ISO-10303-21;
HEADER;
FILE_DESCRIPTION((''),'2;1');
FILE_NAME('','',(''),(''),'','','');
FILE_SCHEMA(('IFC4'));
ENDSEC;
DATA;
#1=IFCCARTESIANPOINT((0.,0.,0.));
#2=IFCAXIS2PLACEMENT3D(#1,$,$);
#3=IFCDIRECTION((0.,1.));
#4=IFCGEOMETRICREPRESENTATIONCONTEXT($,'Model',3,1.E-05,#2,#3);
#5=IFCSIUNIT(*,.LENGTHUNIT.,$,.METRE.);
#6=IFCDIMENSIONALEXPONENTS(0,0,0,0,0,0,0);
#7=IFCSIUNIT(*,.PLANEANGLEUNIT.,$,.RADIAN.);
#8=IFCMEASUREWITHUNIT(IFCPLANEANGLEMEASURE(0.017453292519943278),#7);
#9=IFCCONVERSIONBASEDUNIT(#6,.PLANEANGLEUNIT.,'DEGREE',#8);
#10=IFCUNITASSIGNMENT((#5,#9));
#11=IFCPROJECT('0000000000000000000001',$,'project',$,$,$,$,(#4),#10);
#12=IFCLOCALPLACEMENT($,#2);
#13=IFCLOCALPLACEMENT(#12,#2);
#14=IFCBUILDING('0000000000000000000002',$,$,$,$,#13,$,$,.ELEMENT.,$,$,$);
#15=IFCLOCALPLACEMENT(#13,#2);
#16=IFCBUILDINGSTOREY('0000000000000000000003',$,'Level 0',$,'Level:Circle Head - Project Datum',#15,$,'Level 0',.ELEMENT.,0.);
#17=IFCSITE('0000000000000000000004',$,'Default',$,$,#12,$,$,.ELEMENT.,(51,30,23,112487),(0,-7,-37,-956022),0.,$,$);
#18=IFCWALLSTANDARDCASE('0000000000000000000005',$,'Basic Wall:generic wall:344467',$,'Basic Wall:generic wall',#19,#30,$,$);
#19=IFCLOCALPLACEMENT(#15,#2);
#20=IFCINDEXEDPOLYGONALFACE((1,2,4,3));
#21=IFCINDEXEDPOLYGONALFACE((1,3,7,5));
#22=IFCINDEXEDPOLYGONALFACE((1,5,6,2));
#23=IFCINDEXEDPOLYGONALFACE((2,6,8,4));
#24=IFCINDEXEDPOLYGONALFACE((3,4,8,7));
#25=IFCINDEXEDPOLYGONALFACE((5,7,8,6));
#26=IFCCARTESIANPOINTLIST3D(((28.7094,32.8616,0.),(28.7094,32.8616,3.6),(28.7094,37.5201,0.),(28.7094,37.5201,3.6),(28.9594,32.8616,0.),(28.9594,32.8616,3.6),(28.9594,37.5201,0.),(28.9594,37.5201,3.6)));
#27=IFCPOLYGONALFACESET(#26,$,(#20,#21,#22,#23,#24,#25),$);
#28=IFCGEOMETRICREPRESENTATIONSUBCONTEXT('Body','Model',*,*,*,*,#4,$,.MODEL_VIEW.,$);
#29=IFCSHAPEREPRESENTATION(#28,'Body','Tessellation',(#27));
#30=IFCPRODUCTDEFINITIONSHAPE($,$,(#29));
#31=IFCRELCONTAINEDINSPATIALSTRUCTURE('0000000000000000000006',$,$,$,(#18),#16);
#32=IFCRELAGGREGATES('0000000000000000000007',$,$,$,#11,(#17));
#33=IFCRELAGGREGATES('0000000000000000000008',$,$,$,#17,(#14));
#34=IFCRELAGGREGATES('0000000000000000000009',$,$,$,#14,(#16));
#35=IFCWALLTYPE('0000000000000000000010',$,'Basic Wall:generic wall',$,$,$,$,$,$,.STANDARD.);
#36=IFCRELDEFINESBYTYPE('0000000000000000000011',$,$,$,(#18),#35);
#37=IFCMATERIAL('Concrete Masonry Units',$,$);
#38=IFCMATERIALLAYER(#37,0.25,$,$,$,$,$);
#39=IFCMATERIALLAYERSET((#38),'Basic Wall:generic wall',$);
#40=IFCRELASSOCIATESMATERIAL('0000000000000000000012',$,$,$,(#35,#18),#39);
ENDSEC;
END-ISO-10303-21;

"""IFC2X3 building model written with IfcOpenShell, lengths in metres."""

from ifc_helpers import new_model, entity, si_unit, converted_unit, direction, frame, frame_2d, origin, place, context, subcontext, project, spatial, rectangle, extrude, material, layer, layer_set, layer_usage, type_object, element, save


model = new_model("IFC2X3")

# Units and contexts
model_context = context("Model", 3, precision=1e-05, world=origin(), true_north=direction((0.0, 1.0)))
body_context = subcontext(model_context, "Body", "Model", "MODEL_VIEW")
ifc_project = project(units=[si_unit("LENGTHUNIT", "METRE"), converted_unit("PLANEANGLEUNIT", "DEGREE", entity("IfcPlaneAngleMeasure", 0.017453292519943278), si_unit("PLANEANGLEUNIT", "RADIAN"), dimensions=[0, 0, 0, 0, 0, 0, 0])], contexts=[model_context])

# Site, building, storey
site_placement = place(None, origin())
site = spatial("IfcSite", under=ifc_project, at=site_placement, Name="Default", CompositionType="ELEMENT", RefLatitude=(51, 30, 23, 112487), RefLongitude=(0, -7, -37, -956022), RefElevation=0.0)
building_placement = place(site_placement, origin())
building = spatial("IfcBuilding", under=site, at=building_placement, CompositionType="ELEMENT")
storey_placement = place(building_placement, origin())
storey = spatial("IfcBuildingStorey", under=building, at=storey_placement, Name="Level 0", ObjectType="Level:Circle Head - Project Datum", LongName="Level 0", CompositionType="ELEMENT", Elevation=0.0)

# Shared definitions
ifc_material = material(Name="Concrete Masonry Units")
ifc_layer = layer(ifc_material, 0.25)
ifc_layer_set = layer_set([ifc_layer], Name="Basic Wall:generic wall")
wall_type = type_object("IfcWallType", Name="Basic Wall:generic wall", PredefinedType="STANDARD", material=ifc_layer_set)

# Wall
ifc_layer_usage_1 = layer_usage(ifc_layer_set, "AXIS2", "NEGATIVE", 0.125)
wall_1_placement = place(storey_placement, frame((28.8344, 37.5201, 0.0), z_axis=(0.0, 0.0, 1.0), x_axis=(0.0, -1.0, 0.0)))
element("IfcWallStandardCase", 1, at=wall_1_placement, inside=storey, type_object=wall_type, material=ifc_layer_usage_1, Name="Basic Wall:generic wall:344467", ObjectType="Basic Wall:generic wall", context=body_context, shape_type="SweptSolid", body=[
    extrude(rectangle(XDim=4.6586, YDim=0.25, at=frame_2d((2.3293, 0.0), x_axis=(-1.0, 0.0))), origin(), (0.0, 0.0, 1.0), 3.6),
])

save(model, "model.ifc")
